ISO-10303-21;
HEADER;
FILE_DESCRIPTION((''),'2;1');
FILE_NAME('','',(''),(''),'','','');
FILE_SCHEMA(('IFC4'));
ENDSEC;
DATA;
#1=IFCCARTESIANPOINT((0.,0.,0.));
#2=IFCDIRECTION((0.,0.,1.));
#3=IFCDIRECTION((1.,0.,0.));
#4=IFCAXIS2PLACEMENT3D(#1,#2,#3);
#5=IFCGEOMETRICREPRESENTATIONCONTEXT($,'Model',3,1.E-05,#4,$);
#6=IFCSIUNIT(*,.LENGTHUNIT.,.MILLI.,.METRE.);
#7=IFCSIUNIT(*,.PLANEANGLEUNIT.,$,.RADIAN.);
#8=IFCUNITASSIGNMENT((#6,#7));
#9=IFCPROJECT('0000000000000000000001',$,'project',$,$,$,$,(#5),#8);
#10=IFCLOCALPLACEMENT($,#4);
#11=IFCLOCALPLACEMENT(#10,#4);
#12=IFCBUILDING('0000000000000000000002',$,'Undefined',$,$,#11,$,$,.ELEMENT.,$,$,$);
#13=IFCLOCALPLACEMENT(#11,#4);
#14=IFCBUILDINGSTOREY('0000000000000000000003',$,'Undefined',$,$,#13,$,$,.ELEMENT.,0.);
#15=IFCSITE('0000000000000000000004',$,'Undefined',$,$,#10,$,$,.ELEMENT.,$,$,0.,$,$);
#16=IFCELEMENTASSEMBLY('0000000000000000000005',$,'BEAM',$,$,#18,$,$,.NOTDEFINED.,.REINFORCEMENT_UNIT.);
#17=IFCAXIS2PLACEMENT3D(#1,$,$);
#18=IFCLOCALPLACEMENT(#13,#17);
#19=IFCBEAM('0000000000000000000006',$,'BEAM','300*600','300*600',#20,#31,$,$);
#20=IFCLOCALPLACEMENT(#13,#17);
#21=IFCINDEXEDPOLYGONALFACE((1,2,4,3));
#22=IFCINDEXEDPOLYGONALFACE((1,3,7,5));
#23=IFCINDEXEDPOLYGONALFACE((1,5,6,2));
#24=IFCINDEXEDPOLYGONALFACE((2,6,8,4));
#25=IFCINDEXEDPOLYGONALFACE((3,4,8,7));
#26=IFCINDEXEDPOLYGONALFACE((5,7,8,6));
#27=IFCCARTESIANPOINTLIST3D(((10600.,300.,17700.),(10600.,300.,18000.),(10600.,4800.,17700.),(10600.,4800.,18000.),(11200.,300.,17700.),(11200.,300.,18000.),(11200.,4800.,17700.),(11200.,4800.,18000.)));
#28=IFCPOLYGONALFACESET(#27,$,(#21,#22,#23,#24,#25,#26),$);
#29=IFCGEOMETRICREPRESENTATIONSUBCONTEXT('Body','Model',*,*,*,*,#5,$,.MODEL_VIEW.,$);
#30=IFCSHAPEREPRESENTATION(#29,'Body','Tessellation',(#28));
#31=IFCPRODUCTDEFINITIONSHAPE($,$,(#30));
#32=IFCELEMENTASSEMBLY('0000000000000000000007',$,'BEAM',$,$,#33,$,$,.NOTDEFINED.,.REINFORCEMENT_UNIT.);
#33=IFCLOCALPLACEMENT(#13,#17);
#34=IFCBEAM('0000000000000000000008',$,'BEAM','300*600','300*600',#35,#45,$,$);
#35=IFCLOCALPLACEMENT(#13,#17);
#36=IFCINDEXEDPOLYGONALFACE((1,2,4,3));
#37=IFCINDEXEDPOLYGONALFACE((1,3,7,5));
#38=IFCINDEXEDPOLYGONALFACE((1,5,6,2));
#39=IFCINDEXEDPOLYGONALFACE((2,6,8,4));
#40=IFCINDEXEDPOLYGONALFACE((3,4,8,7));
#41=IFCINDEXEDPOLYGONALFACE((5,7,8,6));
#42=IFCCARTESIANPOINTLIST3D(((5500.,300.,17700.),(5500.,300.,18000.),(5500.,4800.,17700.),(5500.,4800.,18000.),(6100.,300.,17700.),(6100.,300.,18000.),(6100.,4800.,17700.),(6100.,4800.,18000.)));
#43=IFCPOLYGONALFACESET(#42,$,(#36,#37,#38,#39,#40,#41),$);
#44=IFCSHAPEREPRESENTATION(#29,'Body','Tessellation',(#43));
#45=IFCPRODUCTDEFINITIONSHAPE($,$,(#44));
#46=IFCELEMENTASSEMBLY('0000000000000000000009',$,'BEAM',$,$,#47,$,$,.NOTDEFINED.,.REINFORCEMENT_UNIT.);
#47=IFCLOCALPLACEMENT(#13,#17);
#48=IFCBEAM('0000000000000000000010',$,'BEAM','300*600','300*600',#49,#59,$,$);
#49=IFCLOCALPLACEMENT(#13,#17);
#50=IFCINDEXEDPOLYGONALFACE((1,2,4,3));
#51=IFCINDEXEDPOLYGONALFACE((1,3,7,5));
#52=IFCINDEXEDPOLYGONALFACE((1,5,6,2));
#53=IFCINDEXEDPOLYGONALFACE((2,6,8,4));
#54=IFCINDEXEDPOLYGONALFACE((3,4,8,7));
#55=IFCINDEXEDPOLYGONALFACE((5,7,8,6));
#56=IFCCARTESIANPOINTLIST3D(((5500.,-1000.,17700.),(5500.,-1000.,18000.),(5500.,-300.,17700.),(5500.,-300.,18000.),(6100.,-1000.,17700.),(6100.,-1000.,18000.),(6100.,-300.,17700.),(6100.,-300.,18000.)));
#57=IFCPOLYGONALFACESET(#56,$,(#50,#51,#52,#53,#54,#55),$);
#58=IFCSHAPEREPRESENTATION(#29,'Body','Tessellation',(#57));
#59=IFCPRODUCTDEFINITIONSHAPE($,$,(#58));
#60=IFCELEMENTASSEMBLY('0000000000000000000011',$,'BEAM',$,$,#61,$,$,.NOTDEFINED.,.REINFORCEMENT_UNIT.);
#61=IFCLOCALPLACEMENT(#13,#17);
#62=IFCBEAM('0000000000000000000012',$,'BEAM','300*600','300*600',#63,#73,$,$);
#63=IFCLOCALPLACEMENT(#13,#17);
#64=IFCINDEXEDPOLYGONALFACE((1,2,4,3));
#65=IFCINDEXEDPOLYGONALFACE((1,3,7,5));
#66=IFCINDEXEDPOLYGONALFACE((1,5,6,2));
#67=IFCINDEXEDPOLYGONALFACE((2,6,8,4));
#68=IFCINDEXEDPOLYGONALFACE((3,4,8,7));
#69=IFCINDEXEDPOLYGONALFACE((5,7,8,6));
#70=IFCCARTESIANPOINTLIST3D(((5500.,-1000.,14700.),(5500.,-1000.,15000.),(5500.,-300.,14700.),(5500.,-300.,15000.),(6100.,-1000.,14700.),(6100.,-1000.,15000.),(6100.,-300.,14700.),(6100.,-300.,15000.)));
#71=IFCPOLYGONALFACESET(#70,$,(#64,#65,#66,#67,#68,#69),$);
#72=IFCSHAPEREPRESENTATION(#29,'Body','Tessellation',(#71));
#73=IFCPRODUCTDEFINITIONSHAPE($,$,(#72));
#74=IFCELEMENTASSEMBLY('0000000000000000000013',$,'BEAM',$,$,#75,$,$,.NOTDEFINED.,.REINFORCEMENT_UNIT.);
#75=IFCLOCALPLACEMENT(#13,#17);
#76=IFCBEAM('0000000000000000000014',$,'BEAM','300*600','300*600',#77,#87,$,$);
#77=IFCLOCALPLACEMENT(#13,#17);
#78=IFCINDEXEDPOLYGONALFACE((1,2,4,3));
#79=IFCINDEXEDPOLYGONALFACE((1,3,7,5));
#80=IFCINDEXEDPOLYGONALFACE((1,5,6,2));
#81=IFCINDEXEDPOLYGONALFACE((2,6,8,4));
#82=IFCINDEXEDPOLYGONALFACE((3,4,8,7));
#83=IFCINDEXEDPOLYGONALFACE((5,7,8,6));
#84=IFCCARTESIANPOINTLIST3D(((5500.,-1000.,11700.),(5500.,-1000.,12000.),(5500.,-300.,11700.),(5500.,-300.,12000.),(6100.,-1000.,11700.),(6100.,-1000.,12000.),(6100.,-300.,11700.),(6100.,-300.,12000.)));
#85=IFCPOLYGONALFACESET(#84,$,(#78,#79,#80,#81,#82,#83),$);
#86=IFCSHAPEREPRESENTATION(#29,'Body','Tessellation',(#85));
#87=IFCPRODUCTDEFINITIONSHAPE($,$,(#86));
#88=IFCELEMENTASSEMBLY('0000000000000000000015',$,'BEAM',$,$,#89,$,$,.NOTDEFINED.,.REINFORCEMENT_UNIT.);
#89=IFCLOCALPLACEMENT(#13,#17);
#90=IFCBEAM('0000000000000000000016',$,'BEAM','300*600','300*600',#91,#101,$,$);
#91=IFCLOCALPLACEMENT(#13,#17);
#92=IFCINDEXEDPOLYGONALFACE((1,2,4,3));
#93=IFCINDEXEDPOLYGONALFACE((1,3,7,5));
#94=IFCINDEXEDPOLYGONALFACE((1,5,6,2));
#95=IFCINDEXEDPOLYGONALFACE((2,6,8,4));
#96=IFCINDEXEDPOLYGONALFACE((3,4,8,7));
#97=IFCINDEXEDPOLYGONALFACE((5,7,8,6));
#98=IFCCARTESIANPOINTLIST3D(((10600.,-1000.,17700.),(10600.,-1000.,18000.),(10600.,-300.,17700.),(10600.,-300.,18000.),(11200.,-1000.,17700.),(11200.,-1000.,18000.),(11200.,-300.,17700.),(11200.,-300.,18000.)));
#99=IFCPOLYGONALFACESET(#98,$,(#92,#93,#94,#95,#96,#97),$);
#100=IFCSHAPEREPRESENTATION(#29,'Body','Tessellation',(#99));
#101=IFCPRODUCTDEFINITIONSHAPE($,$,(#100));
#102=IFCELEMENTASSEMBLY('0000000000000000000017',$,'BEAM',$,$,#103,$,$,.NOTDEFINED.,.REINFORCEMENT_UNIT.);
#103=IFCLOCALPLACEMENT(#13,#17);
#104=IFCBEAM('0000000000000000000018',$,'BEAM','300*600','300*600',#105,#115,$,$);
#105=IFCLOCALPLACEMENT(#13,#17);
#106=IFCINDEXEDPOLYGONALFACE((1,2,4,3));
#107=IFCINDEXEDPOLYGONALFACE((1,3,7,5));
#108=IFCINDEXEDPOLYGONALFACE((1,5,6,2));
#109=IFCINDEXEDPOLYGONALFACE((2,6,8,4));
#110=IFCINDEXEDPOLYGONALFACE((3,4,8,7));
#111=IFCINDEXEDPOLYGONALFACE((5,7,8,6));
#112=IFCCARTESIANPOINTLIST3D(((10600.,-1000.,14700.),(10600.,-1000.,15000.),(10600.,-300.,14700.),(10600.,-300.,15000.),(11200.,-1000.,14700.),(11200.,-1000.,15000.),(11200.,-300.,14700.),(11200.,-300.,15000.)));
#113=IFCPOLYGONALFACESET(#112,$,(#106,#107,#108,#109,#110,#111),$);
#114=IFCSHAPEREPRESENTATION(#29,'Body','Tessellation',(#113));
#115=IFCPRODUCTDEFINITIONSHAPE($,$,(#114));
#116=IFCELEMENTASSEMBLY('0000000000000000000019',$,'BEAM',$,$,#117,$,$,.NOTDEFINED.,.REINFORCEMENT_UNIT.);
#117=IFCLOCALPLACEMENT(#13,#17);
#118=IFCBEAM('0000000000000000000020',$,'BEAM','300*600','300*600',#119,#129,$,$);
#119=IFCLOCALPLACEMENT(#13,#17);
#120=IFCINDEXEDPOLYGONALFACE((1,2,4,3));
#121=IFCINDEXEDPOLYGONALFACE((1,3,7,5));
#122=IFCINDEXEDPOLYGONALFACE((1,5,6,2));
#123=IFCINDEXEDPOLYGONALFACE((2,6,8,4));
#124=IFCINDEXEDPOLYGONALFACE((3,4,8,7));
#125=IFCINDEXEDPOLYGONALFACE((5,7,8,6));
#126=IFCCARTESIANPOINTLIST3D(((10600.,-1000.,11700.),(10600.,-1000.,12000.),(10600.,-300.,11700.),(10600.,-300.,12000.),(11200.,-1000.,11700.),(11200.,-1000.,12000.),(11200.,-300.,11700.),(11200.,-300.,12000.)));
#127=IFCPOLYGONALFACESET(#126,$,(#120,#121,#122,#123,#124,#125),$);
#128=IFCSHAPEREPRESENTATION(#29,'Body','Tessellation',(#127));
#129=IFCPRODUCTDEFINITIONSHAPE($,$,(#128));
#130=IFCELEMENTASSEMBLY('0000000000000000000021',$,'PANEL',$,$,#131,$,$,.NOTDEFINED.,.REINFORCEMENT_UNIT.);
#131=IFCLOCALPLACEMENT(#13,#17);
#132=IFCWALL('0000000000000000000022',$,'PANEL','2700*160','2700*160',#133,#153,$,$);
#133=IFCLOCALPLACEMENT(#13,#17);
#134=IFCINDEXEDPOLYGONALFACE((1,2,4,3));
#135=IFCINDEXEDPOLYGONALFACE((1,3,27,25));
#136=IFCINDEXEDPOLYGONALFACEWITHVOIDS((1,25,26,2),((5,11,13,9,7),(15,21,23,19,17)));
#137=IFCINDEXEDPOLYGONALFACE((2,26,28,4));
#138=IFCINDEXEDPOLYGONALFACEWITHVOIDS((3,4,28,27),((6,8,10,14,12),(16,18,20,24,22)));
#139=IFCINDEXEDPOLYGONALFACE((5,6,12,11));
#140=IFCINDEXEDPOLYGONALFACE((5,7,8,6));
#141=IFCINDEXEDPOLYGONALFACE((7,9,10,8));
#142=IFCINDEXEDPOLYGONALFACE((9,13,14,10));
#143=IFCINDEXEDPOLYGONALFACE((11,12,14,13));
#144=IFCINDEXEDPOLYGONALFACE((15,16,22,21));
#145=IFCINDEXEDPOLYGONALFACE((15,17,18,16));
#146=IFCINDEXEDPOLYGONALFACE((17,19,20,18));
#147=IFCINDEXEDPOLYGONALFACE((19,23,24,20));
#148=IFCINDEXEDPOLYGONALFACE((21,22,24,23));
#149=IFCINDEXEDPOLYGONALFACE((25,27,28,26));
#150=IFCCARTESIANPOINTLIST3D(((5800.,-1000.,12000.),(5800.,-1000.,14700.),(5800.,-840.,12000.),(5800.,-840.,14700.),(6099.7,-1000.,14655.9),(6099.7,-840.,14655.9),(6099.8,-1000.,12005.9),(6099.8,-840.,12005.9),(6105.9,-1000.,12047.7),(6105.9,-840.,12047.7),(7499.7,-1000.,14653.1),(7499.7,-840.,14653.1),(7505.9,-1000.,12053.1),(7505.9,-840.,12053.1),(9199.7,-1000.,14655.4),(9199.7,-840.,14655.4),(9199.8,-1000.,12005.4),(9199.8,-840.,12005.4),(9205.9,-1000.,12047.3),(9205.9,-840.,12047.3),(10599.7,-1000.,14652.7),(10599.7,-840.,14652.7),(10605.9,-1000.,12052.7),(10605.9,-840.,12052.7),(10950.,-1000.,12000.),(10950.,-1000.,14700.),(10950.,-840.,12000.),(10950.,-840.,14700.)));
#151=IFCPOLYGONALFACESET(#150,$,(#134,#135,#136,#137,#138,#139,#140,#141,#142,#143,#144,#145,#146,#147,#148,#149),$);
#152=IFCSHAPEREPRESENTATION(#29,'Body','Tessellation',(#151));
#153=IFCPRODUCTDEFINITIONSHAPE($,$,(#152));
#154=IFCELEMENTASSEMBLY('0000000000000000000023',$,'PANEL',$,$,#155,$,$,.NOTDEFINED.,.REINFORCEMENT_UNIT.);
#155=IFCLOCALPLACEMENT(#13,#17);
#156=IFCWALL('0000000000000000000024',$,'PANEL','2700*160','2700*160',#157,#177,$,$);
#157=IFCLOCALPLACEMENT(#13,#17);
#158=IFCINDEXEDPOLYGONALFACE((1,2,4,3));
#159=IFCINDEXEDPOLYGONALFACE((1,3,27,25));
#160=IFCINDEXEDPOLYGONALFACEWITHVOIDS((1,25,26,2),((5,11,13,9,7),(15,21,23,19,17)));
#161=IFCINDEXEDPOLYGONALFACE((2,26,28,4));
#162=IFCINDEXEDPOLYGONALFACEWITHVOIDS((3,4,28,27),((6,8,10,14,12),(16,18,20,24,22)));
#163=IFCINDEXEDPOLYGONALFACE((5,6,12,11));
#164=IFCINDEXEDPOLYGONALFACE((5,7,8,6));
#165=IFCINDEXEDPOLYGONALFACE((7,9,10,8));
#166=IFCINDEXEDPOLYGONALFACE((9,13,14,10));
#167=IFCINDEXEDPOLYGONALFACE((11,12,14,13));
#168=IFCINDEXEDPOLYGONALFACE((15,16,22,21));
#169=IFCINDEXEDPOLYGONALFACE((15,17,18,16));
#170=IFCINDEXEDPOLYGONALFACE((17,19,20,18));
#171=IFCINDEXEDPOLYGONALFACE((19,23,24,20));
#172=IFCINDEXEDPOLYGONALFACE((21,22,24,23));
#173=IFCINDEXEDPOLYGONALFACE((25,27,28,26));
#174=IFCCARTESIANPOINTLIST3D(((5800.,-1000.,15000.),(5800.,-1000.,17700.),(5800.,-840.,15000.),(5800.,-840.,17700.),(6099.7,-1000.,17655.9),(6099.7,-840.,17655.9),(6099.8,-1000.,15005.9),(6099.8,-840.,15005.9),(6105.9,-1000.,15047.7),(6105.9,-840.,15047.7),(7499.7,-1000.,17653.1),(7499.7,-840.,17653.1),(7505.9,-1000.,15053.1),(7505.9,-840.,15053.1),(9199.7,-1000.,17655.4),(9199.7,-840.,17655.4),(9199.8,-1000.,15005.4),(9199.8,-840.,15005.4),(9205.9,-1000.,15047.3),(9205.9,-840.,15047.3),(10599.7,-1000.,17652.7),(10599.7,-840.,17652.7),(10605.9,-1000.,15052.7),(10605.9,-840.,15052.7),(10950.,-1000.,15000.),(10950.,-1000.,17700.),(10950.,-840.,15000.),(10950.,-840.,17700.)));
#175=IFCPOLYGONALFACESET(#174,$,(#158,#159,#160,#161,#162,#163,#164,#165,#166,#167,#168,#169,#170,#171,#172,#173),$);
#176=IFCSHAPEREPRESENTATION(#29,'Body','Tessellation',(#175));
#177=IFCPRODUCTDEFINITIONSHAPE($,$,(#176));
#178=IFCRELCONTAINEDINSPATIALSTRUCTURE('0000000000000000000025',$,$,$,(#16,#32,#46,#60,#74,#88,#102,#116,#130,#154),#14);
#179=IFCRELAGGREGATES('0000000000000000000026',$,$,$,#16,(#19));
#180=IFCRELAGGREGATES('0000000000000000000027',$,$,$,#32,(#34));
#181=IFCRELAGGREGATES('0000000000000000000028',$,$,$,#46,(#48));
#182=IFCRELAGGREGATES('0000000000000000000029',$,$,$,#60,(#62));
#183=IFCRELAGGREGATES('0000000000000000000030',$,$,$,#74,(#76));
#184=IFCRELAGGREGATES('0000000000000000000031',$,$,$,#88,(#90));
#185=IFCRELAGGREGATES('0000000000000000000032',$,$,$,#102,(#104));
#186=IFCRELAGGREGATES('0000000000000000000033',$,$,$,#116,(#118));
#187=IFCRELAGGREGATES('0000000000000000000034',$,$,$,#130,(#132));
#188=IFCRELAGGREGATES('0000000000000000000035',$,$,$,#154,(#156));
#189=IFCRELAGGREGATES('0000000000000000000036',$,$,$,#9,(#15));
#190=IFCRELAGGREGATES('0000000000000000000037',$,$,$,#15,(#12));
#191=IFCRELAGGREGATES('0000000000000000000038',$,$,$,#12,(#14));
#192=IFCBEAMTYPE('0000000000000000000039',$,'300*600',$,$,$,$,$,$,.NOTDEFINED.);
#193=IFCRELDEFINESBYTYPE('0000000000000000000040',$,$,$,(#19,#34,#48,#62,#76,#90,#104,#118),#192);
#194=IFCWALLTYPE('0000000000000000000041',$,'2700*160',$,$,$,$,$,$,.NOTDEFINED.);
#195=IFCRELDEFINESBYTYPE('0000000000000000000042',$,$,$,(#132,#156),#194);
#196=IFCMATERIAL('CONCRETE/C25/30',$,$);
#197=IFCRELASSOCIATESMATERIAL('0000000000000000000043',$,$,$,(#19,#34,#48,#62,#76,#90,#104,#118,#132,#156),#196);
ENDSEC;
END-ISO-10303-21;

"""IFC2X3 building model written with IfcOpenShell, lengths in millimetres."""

from ifc_helpers import new_model, si_unit, frame, frame_2d, origin_with_axes, origin_2d_with_axis, place, context, subcontext, project, spatial, polyline, rectangle, outline, extrude, boolean, material, type_object, element, aggregate, save


model = new_model("IFC2X3")

# Units and contexts
model_context = context("Model", 3, precision=1e-05, world=origin_with_axes())
body_context = subcontext(model_context, "Body", "Model", "MODEL_VIEW")
ifc_project = project(units=[si_unit("LENGTHUNIT", "METRE", prefix="MILLI"), si_unit("PLANEANGLEUNIT", "RADIAN")], contexts=[model_context])

# Site, building, storey
site_placement = place(None, origin_with_axes())
site = spatial("IfcSite", under=ifc_project, at=site_placement, Name="Undefined", CompositionType="ELEMENT", RefElevation=0.0)
building_placement = place(site_placement, origin_with_axes())
building = spatial("IfcBuilding", under=site, at=building_placement, Name="Undefined", CompositionType="ELEMENT")
storey_placement = place(building_placement, origin_with_axes())
storey = spatial("IfcBuildingStorey", under=building, at=storey_placement, Name="Undefined", CompositionType="ELEMENT", Elevation=0.0)

# Shared definitions
ifc_material = material(Name="CONCRETE/C25/30")

# Element assemblies, beams
beam_type_1 = type_object("IfcBeamType", Name="300*600", PredefinedType="NOTDEFINED")
assembly_1_placement = place(storey_placement, origin_with_axes())
assembly_1 = element("IfcElementAssembly", 1, at=assembly_1_placement, inside=storey, Name="BEAM", AssemblyPlace="NOTDEFINED", PredefinedType="REINFORCEMENT_UNIT")
beam_1_placement = place(assembly_1_placement, frame((10900.0, 0.0, 17850.0), z_axis=(0.0, 0.0, 1.0), x_axis=(0.0, 1.0, 0.0)))
beam_1 = element("IfcBeam", 2, at=beam_1_placement, type_object=beam_type_1, material=ifc_material, Name="BEAM", Description="300*600", ObjectType="300*600", context=body_context, shape_type="SweptSolid", body=[
    extrude(rectangle(XDim=600.0, YDim=300.0, at=origin_2d_with_axis()), frame((4800.0, 0.0, 0.0), z_axis=(-1.0, 0.0, 0.0), x_axis=(0.0, -1.0, 0.0)), (0.0, 0.0, 1.0), 4500.0),
])
aggregate(assembly_1, [beam_1])
assembly_2_placement = place(storey_placement, origin_with_axes())
assembly_2 = element("IfcElementAssembly", 3, at=assembly_2_placement, inside=storey, Name="BEAM", AssemblyPlace="NOTDEFINED", PredefinedType="REINFORCEMENT_UNIT")
beam_2_placement = place(assembly_2_placement, frame((5800.0, 0.0, 17850.0), z_axis=(0.0, 0.0, 1.0), x_axis=(0.0, 1.0, 0.0)))
beam_2 = element("IfcBeam", 4, at=beam_2_placement, type_object=beam_type_1, material=ifc_material, Name="BEAM", Description="300*600", ObjectType="300*600", context=body_context, shape_type="SweptSolid", body=[
    extrude(rectangle(XDim=600.0, YDim=300.0, at=origin_2d_with_axis()), frame((4800.0, 0.0, 0.0), z_axis=(-1.0, 0.0, 0.0), x_axis=(0.0, -1.0, 0.0)), (0.0, 0.0, 1.0), 4500.0),
])
aggregate(assembly_2, [beam_2])
assembly_3_placement = place(storey_placement, origin_with_axes())
assembly_3 = element("IfcElementAssembly", 5, at=assembly_3_placement, inside=storey, Name="BEAM", AssemblyPlace="NOTDEFINED", PredefinedType="REINFORCEMENT_UNIT")
beam_3_placement = place(assembly_3_placement, frame((5800.0, -300.0, 17850.0), z_axis=(0.0, 0.0, 1.0), x_axis=(0.0, -1.0, 0.0)))
beam_3 = element("IfcBeam", 6, at=beam_3_placement, type_object=beam_type_1, material=ifc_material, Name="BEAM", Description="300*600", ObjectType="300*600", context=body_context, shape_type="SweptSolid", body=[
    extrude(rectangle(XDim=600.0, YDim=300.0, at=origin_2d_with_axis()), frame((700.0, 0.0, 0.0), z_axis=(-1.0, 0.0, 0.0), x_axis=(0.0, -1.0, 0.0)), (0.0, 0.0, 1.0), 700.0),
])
aggregate(assembly_3, [beam_3])
assembly_4_placement = place(storey_placement, origin_with_axes())
assembly_4 = element("IfcElementAssembly", 7, at=assembly_4_placement, inside=storey, Name="BEAM", AssemblyPlace="NOTDEFINED", PredefinedType="REINFORCEMENT_UNIT")
beam_4_placement = place(assembly_4_placement, frame((5800.0, -300.0, 14850.0), z_axis=(0.0, 0.0, 1.0), x_axis=(0.0, -1.0, 0.0)))
beam_4 = element("IfcBeam", 8, at=beam_4_placement, type_object=beam_type_1, material=ifc_material, Name="BEAM", Description="300*600", ObjectType="300*600", context=body_context, shape_type="SweptSolid", body=[
    extrude(rectangle(XDim=600.0, YDim=300.0, at=origin_2d_with_axis()), frame((700.0, 0.0, 0.0), z_axis=(-1.0, 0.0, 0.0), x_axis=(0.0, -1.0, 0.0)), (0.0, 0.0, 1.0), 700.0),
])
aggregate(assembly_4, [beam_4])
assembly_5_placement = place(storey_placement, origin_with_axes())
assembly_5 = element("IfcElementAssembly", 9, at=assembly_5_placement, inside=storey, Name="BEAM", AssemblyPlace="NOTDEFINED", PredefinedType="REINFORCEMENT_UNIT")
beam_5_placement = place(assembly_5_placement, frame((5800.0, -300.0, 11850.0), z_axis=(0.0, 0.0, 1.0), x_axis=(0.0, -1.0, 0.0)))
beam_5 = element("IfcBeam", 10, at=beam_5_placement, type_object=beam_type_1, material=ifc_material, Name="BEAM", Description="300*600", ObjectType="300*600", context=body_context, shape_type="SweptSolid", body=[
    extrude(rectangle(XDim=600.0, YDim=300.0, at=origin_2d_with_axis()), frame((700.0, 0.0, 0.0), z_axis=(-1.0, 0.0, 0.0), x_axis=(0.0, -1.0, 0.0)), (0.0, 0.0, 1.0), 700.0),
])
aggregate(assembly_5, [beam_5])
assembly_6_placement = place(storey_placement, origin_with_axes())
assembly_6 = element("IfcElementAssembly", 11, at=assembly_6_placement, inside=storey, Name="BEAM", AssemblyPlace="NOTDEFINED", PredefinedType="REINFORCEMENT_UNIT")
beam_6_placement = place(assembly_6_placement, frame((10900.0, -300.0, 17850.0), z_axis=(0.0, 0.0, 1.0), x_axis=(0.0, -1.0, 0.0)))
beam_6 = element("IfcBeam", 12, at=beam_6_placement, type_object=beam_type_1, material=ifc_material, Name="BEAM", Description="300*600", ObjectType="300*600", context=body_context, shape_type="SweptSolid", body=[
    extrude(rectangle(XDim=600.0, YDim=300.0, at=origin_2d_with_axis()), frame((700.0, 0.0, 0.0), z_axis=(-1.0, 0.0, 0.0), x_axis=(0.0, -1.0, 0.0)), (0.0, 0.0, 1.0), 700.0),
])
aggregate(assembly_6, [beam_6])
assembly_7_placement = place(storey_placement, origin_with_axes())
assembly_7 = element("IfcElementAssembly", 13, at=assembly_7_placement, inside=storey, Name="BEAM", AssemblyPlace="NOTDEFINED", PredefinedType="REINFORCEMENT_UNIT")
beam_7_placement = place(assembly_7_placement, frame((10900.0, -300.0, 14850.0), z_axis=(0.0, 0.0, 1.0), x_axis=(0.0, -1.0, 0.0)))
beam_7 = element("IfcBeam", 14, at=beam_7_placement, type_object=beam_type_1, material=ifc_material, Name="BEAM", Description="300*600", ObjectType="300*600", context=body_context, shape_type="SweptSolid", body=[
    extrude(rectangle(XDim=600.0, YDim=300.0, at=origin_2d_with_axis()), frame((700.0, 0.0, 0.0), z_axis=(-1.0, 0.0, 0.0), x_axis=(0.0, -1.0, 0.0)), (0.0, 0.0, 1.0), 700.0),
])
aggregate(assembly_7, [beam_7])
assembly_8_placement = place(storey_placement, origin_with_axes())
assembly_8 = element("IfcElementAssembly", 15, at=assembly_8_placement, inside=storey, Name="BEAM", AssemblyPlace="NOTDEFINED", PredefinedType="REINFORCEMENT_UNIT")
beam_8_placement = place(assembly_8_placement, frame((10900.0, -300.0, 11850.0), z_axis=(0.0, 0.0, 1.0), x_axis=(0.0, -1.0, 0.0)))
beam_8 = element("IfcBeam", 16, at=beam_8_placement, type_object=beam_type_1, material=ifc_material, Name="BEAM", Description="300*600", ObjectType="300*600", context=body_context, shape_type="SweptSolid", body=[
    extrude(rectangle(XDim=600.0, YDim=300.0, at=origin_2d_with_axis()), frame((700.0, 0.0, 0.0), z_axis=(-1.0, 0.0, 0.0), x_axis=(0.0, -1.0, 0.0)), (0.0, 0.0, 1.0), 700.0),
])
aggregate(assembly_8, [beam_8])

# Element assemblies, walls
assembly_9_placement = place(storey_placement, origin_with_axes())
assembly_9 = element("IfcElementAssembly", 17, at=assembly_9_placement, inside=storey, Name="PANEL", AssemblyPlace="NOTDEFINED", PredefinedType="REINFORCEMENT_UNIT")
wall_type = type_object("IfcWallType", Name="2700*160", PredefinedType="NOTDEFINED")
wall_1_placement = place(assembly_9_placement, frame((5800.0, -920.0, 12000.0), z_axis=(0.0, 0.0, 1.0), x_axis=(1.0, 0.0, 0.0)))
wall_1 = element("IfcWall", 18, at=wall_1_placement, type_object=wall_type, material=ifc_material, Name="PANEL", Description="2700*160", ObjectType="2700*160", context=body_context, shape_type="CSG", body=[
    boolean("DIFFERENCE", boolean("DIFFERENCE", extrude(rectangle(XDim=5150.0, YDim=160.0, at=frame_2d((0.0, 2575.0), x_axis=(0.0, -1.0))), frame((0.0, 0.0, 0.0), z_axis=(0.0, 0.0, 1.0), x_axis=(0.0, -1.0, 0.0)), (0.0, 0.0, 1.0), 2700.0), extrude(outline(polyline([(0.0, 0.0), (2650.0, 0.0), (2647.2, 1400.0), (47.2, 1406.1), (41.9, 6.1), (0.0, 0.0), (0.0, 0.0)])), frame((299.8, -82.5, 5.9), z_axis=(0.0, 1.0, 0.0), x_axis=(-0.00004, 0.0, 1.0)), (0.0, 0.0, 1.0), 165.0)), extrude(outline(polyline([(0.0, 0.0), (2650.0, 0.0), (2647.2, 1400.0), (47.2, 1406.1), (41.9, 6.1), (0.0, 0.0), (0.0, 0.0)])), frame((3399.8, -82.5, 5.4), z_axis=(0.0, 1.0, 0.0), x_axis=(-0.00004, 0.0, 1.0)), (0.0, 0.0, 1.0), 165.0)),
])
aggregate(assembly_9, [wall_1])
assembly_10_placement = place(storey_placement, origin_with_axes())
assembly_10 = element("IfcElementAssembly", 19, at=assembly_10_placement, inside=storey, Name="PANEL", AssemblyPlace="NOTDEFINED", PredefinedType="REINFORCEMENT_UNIT")
wall_2_placement = place(assembly_10_placement, frame((5800.0, -920.0, 15000.0), z_axis=(0.0, 0.0, 1.0), x_axis=(1.0, 0.0, 0.0)))
wall_2 = element("IfcWall", 20, at=wall_2_placement, type_object=wall_type, material=ifc_material, Name="PANEL", Description="2700*160", ObjectType="2700*160", context=body_context, shape_type="CSG", body=[
    boolean("DIFFERENCE", boolean("DIFFERENCE", extrude(rectangle(XDim=5150.0, YDim=160.0, at=frame_2d((0.0, 2575.0), x_axis=(0.0, -1.0))), frame((0.0, 0.0, 0.0), z_axis=(0.0, 0.0, 1.0), x_axis=(0.0, -1.0, 0.0)), (0.0, 0.0, 1.0), 2700.0), extrude(outline(polyline([(0.0, 0.0), (2650.0, 0.0), (2647.2, 1400.0), (47.2, 1406.1), (41.9, 6.1), (0.0, 0.0), (0.0, 0.0)])), frame((299.8, -82.5, 5.9), z_axis=(0.0, 1.0, 0.0), x_axis=(-0.00004, 0.0, 1.0)), (0.0, 0.0, 1.0), 165.0)), extrude(outline(polyline([(0.0, 0.0), (2650.0, 0.0), (2647.2, 1400.0), (47.2, 1406.1), (41.9, 6.1), (0.0, 0.0), (0.0, 0.0)])), frame((3399.8, -82.5, 5.4), z_axis=(0.0, 1.0, 0.0), x_axis=(-0.00004, 0.0, 1.0)), (0.0, 0.0, 1.0), 165.0)),
])
aggregate(assembly_10, [wall_2])

save(model, "model.ifc")
